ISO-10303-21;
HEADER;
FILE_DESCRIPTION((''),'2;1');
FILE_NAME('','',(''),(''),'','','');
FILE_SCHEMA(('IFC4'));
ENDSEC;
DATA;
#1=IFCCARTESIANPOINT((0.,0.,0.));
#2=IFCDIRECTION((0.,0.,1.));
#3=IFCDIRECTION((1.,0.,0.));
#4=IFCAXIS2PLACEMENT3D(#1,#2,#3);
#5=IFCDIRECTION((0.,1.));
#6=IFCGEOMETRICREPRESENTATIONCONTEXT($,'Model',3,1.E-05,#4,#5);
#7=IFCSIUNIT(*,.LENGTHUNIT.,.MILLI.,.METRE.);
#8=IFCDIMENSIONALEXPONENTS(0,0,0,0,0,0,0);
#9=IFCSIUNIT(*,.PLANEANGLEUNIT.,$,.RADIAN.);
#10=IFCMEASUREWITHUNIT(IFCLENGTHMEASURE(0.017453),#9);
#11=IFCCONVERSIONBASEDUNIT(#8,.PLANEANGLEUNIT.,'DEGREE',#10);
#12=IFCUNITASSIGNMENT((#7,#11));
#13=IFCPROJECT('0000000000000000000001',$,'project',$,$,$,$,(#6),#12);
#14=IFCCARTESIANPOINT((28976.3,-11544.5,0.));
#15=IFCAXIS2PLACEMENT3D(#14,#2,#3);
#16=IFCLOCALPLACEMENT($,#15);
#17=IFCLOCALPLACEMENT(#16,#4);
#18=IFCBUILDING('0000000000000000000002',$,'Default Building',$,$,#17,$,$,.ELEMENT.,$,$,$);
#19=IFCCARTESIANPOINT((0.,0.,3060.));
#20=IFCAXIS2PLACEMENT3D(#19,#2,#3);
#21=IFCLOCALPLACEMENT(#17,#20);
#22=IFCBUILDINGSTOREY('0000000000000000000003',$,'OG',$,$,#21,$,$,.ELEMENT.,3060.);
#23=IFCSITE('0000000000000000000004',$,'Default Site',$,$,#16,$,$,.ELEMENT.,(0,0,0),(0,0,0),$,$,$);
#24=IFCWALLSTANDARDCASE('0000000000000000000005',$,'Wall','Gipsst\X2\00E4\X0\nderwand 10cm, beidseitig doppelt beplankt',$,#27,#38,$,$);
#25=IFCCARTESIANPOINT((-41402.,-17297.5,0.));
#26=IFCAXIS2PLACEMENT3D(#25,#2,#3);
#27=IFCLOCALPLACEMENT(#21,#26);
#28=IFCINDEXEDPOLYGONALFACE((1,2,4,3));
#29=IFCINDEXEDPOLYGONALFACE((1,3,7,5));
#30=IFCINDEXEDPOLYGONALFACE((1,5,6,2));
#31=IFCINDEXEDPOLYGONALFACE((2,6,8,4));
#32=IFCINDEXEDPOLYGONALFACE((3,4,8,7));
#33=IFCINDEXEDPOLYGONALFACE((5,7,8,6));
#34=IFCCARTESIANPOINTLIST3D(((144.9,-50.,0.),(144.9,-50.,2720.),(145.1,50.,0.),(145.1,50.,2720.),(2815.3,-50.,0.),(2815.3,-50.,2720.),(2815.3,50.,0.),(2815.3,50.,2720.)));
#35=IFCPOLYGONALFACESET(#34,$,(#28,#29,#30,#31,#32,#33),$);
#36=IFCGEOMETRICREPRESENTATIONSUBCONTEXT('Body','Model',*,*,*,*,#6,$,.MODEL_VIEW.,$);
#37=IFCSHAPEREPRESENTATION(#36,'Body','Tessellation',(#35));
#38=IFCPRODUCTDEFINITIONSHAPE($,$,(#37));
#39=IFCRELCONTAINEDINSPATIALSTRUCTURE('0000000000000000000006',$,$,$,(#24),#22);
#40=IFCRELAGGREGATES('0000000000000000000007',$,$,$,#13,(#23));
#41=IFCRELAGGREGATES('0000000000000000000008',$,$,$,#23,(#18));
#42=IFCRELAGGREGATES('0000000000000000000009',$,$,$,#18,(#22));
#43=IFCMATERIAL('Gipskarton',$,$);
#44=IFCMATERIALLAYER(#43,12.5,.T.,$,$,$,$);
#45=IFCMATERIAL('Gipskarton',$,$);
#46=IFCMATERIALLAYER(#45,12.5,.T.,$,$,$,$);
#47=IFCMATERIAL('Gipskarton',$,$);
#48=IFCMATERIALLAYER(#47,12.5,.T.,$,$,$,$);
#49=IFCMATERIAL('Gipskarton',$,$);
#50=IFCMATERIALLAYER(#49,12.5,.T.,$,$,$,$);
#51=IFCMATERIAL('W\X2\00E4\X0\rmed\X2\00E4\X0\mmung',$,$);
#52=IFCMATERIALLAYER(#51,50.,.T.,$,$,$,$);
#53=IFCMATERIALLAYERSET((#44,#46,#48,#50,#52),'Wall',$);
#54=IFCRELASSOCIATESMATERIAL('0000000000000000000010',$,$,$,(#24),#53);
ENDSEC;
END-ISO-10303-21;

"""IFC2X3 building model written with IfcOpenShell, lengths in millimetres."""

from ifc_helpers import new_model, entity, si_unit, converted_unit, direction, frame, origin_with_axes, place, context, subcontext, project, spatial, polyline, outline, extrude, material, layer, layer_set, layer_usage, element, save


model = new_model("IFC2X3")

# Units and contexts
model_context = context("Model", 3, precision=1e-05, world=origin_with_axes(), true_north=direction((0.0, 1.0)))
body_context = subcontext(model_context, "Body", "Model", "MODEL_VIEW")
ifc_project = project(units=[si_unit("LENGTHUNIT", "METRE", prefix="MILLI"), converted_unit("PLANEANGLEUNIT", "DEGREE", entity("IfcLengthMeasure", 0.017453), si_unit("PLANEANGLEUNIT", "RADIAN"), dimensions=[0, 0, 0, 0, 0, 0, 0])], contexts=[model_context])

# Site, building, storey
site_placement = place(None, frame((28976.3, -11544.5, 0.0), z_axis=(0.0, 0.0, 1.0), x_axis=(1.0, 0.0, 0.0)))
site = spatial("IfcSite", under=ifc_project, at=site_placement, Name="Default Site", CompositionType="ELEMENT", RefLatitude=(0, 0, 0), RefLongitude=(0, 0, 0))
building_placement = place(site_placement, origin_with_axes())
building = spatial("IfcBuilding", under=site, at=building_placement, Name="Default Building", CompositionType="ELEMENT")
storey_placement = place(building_placement, frame((0.0, 0.0, 3060.0), z_axis=(0.0, 0.0, 1.0), x_axis=(1.0, 0.0, 0.0)))
storey = spatial("IfcBuildingStorey", under=building, at=storey_placement, Name="OG", CompositionType="ELEMENT", Elevation=3060.0)

# Wall
ifc_material_1 = material(Name="Gipskarton")
ifc_layer_1 = layer(ifc_material_1, 12.5, ventilated=True)
ifc_material_2 = material(Name="Gipskarton")
ifc_layer_2 = layer(ifc_material_2, 12.5, ventilated=True)
ifc_material_3 = material(Name="Gipskarton")
ifc_layer_3 = layer(ifc_material_3, 12.5, ventilated=True)
ifc_material_4 = material(Name="Gipskarton")
ifc_layer_4 = layer(ifc_material_4, 12.5, ventilated=True)
ifc_material_5 = material(Name="Wärmedämmung")
ifc_layer_5 = layer(ifc_material_5, 50.0, ventilated=True)
ifc_layer_set_1 = layer_set([ifc_layer_1, ifc_layer_2, ifc_layer_3, ifc_layer_4, ifc_layer_5], Name="Wall")
ifc_layer_usage_1 = layer_usage(ifc_layer_set_1, "AXIS2", "POSITIVE", -50.0)
wall_1_placement = place(storey_placement, frame((-41402.0, -17297.5, 0.0), z_axis=(0.0, 0.0, 1.0), x_axis=(1.0, 0.0, 0.0)))
element("IfcWallStandardCase", 1, at=wall_1_placement, inside=storey, material=ifc_layer_usage_1, Name="Wall", Description="Gipsständerwand 10cm, beidseitig doppelt beplankt", context=body_context, shape_type="SweptSolid", body=[
    extrude(outline(polyline([(2815.3, 50.0), (145.1, 50.0), (144.9, -50.0), (2815.3, -50.0), (2815.3, 50.0)])), origin_with_axes(), (0.0, 0.0, 1.0), 2720.0),
])

save(model, "model.ifc")
